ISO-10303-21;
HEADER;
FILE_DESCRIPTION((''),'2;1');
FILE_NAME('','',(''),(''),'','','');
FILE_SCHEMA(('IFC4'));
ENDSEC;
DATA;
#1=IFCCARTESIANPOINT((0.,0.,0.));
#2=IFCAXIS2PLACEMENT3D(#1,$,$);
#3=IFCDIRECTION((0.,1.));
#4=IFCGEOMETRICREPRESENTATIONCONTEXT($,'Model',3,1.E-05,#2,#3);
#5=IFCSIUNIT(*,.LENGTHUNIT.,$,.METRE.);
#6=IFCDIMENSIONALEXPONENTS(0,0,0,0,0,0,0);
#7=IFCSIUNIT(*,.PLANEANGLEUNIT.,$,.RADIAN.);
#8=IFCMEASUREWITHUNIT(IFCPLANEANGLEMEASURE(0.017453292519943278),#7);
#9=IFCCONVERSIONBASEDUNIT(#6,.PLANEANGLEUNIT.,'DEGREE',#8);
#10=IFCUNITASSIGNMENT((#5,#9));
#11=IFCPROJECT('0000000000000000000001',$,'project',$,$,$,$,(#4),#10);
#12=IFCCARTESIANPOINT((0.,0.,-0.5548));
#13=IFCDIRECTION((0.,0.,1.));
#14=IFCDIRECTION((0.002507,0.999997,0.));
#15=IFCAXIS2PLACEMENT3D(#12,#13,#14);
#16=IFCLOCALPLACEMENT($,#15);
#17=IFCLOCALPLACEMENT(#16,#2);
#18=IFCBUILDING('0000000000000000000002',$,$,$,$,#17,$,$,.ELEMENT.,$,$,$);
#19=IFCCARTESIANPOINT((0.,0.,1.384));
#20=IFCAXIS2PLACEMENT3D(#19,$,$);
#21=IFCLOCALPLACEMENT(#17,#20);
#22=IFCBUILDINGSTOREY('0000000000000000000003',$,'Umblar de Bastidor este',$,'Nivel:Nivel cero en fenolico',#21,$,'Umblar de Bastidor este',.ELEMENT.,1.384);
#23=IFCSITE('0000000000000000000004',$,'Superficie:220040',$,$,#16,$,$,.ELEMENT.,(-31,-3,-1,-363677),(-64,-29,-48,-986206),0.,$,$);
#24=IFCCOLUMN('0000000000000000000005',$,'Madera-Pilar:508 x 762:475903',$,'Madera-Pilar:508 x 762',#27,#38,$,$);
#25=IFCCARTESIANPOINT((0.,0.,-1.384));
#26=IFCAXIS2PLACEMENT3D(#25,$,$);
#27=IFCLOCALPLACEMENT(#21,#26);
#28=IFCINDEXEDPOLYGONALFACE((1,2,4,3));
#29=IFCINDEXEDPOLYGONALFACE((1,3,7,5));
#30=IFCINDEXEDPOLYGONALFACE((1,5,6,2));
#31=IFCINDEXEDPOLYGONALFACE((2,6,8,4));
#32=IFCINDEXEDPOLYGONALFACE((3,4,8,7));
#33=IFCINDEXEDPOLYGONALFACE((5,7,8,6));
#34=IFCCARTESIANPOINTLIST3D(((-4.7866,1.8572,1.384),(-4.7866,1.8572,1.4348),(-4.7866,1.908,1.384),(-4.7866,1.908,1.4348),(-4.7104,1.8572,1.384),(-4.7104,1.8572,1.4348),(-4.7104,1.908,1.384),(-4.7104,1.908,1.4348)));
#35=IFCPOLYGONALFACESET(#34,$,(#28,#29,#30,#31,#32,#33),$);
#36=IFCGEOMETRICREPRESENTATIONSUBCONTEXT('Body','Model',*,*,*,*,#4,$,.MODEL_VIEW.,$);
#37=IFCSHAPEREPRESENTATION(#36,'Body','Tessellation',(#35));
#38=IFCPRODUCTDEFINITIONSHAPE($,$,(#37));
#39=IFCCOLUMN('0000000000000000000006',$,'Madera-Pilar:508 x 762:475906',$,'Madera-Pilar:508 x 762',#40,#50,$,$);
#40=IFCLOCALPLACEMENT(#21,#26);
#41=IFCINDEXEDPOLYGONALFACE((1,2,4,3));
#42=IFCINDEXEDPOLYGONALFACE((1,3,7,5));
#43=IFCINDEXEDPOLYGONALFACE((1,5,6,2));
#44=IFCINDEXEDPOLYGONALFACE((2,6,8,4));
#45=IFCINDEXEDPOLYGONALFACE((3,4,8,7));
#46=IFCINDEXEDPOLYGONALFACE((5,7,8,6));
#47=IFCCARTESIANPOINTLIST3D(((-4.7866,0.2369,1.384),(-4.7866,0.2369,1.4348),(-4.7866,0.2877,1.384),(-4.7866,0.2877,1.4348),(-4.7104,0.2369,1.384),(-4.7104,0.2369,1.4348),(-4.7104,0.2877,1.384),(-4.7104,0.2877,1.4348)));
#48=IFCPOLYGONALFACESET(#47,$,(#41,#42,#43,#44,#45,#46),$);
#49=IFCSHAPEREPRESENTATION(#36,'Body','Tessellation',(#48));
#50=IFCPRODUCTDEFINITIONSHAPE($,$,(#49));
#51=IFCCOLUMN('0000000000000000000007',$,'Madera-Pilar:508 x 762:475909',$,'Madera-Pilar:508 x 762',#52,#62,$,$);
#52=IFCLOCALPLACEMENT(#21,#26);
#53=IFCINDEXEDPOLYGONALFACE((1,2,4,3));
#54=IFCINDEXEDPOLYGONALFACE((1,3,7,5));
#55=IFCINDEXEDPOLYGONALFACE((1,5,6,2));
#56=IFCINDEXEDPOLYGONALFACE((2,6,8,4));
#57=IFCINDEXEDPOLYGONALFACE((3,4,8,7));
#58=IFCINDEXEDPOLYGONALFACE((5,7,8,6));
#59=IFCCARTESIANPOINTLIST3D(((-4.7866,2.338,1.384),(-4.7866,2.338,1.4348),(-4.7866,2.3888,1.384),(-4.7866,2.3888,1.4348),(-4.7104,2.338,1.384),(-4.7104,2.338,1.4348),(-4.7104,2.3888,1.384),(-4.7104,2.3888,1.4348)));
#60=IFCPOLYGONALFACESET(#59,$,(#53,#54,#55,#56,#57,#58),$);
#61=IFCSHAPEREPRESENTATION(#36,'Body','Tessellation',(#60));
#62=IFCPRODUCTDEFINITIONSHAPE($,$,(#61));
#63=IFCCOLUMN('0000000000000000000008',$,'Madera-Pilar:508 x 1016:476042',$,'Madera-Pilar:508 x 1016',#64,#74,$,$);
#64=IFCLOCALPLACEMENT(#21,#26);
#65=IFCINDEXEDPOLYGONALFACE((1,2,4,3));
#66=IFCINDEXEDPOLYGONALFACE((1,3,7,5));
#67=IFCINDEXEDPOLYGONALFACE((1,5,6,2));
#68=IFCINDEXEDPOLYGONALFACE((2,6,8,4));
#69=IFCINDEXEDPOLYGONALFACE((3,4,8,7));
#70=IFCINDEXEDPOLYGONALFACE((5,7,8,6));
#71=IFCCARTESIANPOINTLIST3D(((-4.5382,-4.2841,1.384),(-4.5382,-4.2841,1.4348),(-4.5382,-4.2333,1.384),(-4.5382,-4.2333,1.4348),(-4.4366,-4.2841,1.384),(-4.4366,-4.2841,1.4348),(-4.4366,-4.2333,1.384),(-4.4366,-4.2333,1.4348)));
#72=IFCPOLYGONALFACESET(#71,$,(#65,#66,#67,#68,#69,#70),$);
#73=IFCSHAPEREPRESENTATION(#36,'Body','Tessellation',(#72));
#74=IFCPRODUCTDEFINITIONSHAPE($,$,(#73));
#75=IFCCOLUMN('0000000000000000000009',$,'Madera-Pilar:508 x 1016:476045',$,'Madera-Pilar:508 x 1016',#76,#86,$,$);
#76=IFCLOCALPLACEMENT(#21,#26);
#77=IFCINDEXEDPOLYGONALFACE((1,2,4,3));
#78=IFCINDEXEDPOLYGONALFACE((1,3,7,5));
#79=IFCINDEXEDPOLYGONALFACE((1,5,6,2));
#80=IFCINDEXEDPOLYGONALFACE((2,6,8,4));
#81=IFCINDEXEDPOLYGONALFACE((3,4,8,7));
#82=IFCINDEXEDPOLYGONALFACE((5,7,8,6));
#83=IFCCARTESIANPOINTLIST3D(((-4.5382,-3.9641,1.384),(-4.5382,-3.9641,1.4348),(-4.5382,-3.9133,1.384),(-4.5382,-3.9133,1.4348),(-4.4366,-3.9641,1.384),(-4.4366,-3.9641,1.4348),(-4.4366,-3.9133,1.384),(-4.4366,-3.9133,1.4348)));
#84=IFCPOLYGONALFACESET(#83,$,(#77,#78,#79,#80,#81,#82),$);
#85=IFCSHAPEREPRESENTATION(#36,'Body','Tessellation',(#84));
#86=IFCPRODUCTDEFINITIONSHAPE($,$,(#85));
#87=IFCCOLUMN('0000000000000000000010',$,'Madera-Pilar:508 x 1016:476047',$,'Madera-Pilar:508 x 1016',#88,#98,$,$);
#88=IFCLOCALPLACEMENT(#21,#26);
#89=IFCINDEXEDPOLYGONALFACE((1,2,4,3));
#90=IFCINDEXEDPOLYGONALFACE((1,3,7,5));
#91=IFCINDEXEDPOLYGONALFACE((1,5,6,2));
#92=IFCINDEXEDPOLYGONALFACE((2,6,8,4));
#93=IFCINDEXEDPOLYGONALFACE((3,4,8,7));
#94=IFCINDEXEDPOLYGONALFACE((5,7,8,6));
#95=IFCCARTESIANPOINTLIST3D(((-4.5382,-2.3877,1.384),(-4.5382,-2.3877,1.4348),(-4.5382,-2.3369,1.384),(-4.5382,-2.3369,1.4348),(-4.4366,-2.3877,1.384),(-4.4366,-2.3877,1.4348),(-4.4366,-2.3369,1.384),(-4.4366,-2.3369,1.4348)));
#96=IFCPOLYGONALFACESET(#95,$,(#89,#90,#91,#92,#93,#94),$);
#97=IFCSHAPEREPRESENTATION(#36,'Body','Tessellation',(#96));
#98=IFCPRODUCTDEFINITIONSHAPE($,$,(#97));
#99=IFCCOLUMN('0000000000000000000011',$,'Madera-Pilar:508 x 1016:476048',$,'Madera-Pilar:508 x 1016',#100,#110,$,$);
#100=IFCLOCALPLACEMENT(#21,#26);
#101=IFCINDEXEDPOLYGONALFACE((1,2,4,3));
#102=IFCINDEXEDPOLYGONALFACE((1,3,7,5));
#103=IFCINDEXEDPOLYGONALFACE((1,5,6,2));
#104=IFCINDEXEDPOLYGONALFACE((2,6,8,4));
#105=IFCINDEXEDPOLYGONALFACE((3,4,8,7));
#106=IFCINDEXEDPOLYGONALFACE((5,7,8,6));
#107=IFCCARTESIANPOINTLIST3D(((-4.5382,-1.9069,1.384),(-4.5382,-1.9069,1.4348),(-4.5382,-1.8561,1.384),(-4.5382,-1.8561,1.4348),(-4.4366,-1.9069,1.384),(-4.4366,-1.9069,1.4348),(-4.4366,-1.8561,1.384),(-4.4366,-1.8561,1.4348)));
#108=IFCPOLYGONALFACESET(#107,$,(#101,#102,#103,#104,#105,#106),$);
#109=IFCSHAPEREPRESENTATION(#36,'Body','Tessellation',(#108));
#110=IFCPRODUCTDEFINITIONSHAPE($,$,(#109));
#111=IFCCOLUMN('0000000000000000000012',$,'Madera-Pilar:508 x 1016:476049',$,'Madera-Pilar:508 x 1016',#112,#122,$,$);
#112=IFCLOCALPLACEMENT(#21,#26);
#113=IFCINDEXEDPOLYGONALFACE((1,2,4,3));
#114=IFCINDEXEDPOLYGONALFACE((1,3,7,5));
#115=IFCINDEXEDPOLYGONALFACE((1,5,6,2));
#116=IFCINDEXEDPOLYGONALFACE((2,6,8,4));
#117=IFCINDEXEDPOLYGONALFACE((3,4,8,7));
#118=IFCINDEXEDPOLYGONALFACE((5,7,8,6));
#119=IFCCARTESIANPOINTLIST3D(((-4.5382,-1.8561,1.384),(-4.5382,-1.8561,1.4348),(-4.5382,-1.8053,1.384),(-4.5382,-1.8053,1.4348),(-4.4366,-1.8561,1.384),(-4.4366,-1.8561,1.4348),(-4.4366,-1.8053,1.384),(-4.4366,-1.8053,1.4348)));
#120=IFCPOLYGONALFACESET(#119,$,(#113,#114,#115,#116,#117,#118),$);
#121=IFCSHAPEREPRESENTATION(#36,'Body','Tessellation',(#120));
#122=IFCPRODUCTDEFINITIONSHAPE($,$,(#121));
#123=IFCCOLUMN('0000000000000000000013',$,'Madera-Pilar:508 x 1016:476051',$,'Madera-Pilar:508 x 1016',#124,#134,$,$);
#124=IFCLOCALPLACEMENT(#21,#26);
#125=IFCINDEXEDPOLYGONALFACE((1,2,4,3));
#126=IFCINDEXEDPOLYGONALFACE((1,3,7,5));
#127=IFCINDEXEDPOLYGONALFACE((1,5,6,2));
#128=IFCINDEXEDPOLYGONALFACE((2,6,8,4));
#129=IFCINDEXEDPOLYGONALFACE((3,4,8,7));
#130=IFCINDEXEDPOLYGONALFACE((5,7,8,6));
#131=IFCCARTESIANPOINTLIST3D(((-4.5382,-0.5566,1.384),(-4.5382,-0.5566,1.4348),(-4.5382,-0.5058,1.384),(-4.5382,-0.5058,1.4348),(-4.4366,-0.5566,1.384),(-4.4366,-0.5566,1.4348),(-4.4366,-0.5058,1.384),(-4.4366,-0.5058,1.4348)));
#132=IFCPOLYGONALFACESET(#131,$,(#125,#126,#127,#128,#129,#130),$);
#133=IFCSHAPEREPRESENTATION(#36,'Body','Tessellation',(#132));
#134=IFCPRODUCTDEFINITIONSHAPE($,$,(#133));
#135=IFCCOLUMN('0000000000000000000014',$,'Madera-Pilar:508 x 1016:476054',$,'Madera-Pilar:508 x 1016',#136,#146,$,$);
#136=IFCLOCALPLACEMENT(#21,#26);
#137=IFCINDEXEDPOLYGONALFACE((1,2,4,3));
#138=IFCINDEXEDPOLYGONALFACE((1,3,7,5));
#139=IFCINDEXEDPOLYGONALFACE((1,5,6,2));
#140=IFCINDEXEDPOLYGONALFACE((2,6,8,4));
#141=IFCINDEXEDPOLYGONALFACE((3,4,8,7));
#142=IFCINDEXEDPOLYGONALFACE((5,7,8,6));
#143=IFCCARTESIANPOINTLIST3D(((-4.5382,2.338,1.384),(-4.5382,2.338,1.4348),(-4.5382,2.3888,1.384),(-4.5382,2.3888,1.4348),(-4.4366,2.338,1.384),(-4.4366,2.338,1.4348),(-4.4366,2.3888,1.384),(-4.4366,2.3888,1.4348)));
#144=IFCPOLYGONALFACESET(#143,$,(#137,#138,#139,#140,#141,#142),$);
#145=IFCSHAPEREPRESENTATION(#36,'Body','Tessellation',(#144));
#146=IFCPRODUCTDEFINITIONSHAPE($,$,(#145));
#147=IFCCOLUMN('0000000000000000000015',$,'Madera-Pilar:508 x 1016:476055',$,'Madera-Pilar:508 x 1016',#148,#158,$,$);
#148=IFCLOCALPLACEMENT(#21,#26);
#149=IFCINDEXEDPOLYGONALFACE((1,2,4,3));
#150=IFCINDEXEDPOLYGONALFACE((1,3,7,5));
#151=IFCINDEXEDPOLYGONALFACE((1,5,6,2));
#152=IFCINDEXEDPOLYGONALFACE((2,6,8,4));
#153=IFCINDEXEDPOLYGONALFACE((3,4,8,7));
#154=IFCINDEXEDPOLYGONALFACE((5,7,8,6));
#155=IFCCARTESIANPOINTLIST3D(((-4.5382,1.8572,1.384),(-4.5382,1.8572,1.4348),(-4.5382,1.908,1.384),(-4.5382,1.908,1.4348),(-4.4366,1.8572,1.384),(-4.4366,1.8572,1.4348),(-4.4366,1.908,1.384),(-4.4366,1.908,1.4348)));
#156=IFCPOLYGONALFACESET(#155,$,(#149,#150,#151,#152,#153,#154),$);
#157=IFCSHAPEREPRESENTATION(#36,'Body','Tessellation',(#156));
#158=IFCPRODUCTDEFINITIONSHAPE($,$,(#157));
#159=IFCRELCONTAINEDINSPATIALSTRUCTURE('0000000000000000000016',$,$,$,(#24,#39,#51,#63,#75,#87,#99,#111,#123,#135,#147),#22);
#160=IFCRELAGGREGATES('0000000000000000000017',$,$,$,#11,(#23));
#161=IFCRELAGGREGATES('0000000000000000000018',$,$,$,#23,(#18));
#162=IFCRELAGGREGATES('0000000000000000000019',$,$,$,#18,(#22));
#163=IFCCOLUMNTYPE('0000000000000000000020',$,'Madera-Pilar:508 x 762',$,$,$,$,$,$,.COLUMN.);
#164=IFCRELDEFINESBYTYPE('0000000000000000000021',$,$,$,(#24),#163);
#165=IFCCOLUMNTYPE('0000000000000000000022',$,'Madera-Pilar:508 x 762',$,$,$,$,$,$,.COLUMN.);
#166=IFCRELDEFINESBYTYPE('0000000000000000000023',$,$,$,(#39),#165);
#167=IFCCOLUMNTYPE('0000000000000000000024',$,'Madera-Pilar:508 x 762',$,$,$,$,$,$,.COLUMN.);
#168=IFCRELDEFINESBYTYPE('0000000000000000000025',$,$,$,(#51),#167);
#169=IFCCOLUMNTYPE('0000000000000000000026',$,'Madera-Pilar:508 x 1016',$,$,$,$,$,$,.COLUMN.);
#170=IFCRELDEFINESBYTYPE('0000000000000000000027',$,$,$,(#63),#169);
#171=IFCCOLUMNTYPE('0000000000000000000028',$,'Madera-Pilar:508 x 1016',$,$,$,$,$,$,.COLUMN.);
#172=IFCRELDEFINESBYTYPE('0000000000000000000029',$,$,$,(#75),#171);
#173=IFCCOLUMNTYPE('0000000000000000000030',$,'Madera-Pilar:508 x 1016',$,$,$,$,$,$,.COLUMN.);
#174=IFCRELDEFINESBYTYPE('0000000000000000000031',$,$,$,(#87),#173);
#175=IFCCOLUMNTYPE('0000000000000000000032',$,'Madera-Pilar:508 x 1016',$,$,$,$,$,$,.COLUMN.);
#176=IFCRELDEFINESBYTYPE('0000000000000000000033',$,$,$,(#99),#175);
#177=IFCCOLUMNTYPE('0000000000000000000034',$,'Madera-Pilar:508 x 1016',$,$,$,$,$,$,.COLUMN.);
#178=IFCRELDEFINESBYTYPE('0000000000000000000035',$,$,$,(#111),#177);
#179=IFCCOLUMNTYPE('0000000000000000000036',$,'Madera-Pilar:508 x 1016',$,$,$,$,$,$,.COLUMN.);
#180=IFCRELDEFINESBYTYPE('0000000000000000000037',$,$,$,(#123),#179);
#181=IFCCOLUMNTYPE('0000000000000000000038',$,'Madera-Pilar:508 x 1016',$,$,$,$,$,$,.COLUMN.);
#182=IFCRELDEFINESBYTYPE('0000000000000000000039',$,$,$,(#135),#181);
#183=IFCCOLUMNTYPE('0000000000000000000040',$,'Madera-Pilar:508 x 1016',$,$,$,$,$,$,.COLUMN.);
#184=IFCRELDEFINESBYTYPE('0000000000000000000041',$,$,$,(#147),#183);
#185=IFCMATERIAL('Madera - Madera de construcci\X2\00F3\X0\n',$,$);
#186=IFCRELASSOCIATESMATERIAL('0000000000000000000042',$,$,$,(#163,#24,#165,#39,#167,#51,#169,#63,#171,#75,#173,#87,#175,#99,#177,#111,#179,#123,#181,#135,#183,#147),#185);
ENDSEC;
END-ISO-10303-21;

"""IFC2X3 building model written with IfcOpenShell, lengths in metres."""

from ifc_helpers import new_model, entity, si_unit, converted_unit, direction, frame, frame_2d, origin, origin_2d_with_axis, place, context, subcontext, project, spatial, rectangle, extrude, source, transform, mapped, material, type_object, type_shapes, element, save


model = new_model("IFC2X3")

# Units and contexts
model_context = context("Model", 3, precision=1e-05, world=origin(), true_north=direction((0.0, 1.0)))
body_context = subcontext(model_context, "Body", "Model", "MODEL_VIEW")
ifc_project = project(units=[si_unit("LENGTHUNIT", "METRE"), converted_unit("PLANEANGLEUNIT", "DEGREE", entity("IfcPlaneAngleMeasure", 0.017453292519943278), si_unit("PLANEANGLEUNIT", "RADIAN"), dimensions=[0, 0, 0, 0, 0, 0, 0])], contexts=[model_context])

# Site, building, storey
site_placement = place(None, frame((0.0, 0.0, -0.5548), z_axis=(0.0, 0.0, 1.0), x_axis=(0.002507, 0.999997, 0.0)))
site = spatial("IfcSite", under=ifc_project, at=site_placement, Name="Superficie:220040", CompositionType="ELEMENT", RefLatitude=(-31, -3, -1, -363677), RefLongitude=(-64, -29, -48, -986206), RefElevation=0.0)
building_placement = place(site_placement, origin())
building = spatial("IfcBuilding", under=site, at=building_placement, CompositionType="ELEMENT")
storey_placement = place(building_placement, frame((0.0, 0.0, 1.384)))
storey = spatial("IfcBuildingStorey", under=building, at=storey_placement, Name="Umblar de Bastidor este", ObjectType="Nivel:Nivel cero en fenolico", LongName="Umblar de Bastidor este", CompositionType="ELEMENT", Elevation=1.384)

# Columns
ifc_material = material(Name="Madera - Madera de construcción")
column_type_1 = type_object("IfcColumnType", Name="Madera-Pilar:508 x 762", PredefinedType="COLUMN", material=ifc_material)
shared_shape_1 = source(origin(), body_context, "Body", "SweptSolid", [
    extrude(rectangle(XDim=0.0762, YDim=0.0508, at=origin_2d_with_axis()), frame((-4.7485, 1.8826, 1.384), z_axis=(0.0, 0.0, 1.0), x_axis=(-1.0, 0.0, 0.0)), (0.0, 0.0, 1.0), 0.0508),
])
type_shapes(column_type_1, [shared_shape_1])
column_1_placement = place(storey_placement, frame((0.0, 0.0, -1.384)))
element("IfcColumn", 1, at=column_1_placement, inside=storey, type_object=column_type_1, material=ifc_material, Name="Madera-Pilar:508 x 762:475903", ObjectType="Madera-Pilar:508 x 762", context=body_context, shape_type="MappedRepresentation", body=[
    mapped(shared_shape_1, transform((0.0, 0.0, 0.0), scale=1.0)),
])
column_type_2 = type_object("IfcColumnType", Name="Madera-Pilar:508 x 762", PredefinedType="COLUMN", material=ifc_material)
shared_shape_2 = source(origin(), body_context, "Body", "SweptSolid", [
    extrude(rectangle(XDim=0.0762, YDim=0.0508, at=frame_2d((0.0, 0.0), x_axis=(1.0, 0.0))), frame((-4.7485, 0.2623, 1.384), z_axis=(0.0, 0.0, 1.0), x_axis=(-1.0, 0.0, 0.0)), (0.0, 0.0, 1.0), 0.0508),
])
type_shapes(column_type_2, [shared_shape_2])
column_2_placement = place(storey_placement, frame((0.0, 0.0, -1.384)))
element("IfcColumn", 2, at=column_2_placement, inside=storey, type_object=column_type_2, material=ifc_material, Name="Madera-Pilar:508 x 762:475906", ObjectType="Madera-Pilar:508 x 762", context=body_context, shape_type="MappedRepresentation", body=[
    mapped(shared_shape_2, transform((0.0, 0.0, 0.0), scale=1.0)),
])
column_type_3 = type_object("IfcColumnType", Name="Madera-Pilar:508 x 762", PredefinedType="COLUMN", material=ifc_material)
shared_shape_3 = source(origin(), body_context, "Body", "SweptSolid", [
    extrude(rectangle(XDim=0.0762, YDim=0.0508, at=origin_2d_with_axis()), frame((-4.7485, 2.3634, 1.384), z_axis=(0.0, 0.0, 1.0), x_axis=(-1.0, 0.0, 0.0)), (0.0, 0.0, 1.0), 0.0508),
])
type_shapes(column_type_3, [shared_shape_3])
column_3_placement = place(storey_placement, frame((0.0, 0.0, -1.384)))
element("IfcColumn", 3, at=column_3_placement, inside=storey, type_object=column_type_3, material=ifc_material, Name="Madera-Pilar:508 x 762:475909", ObjectType="Madera-Pilar:508 x 762", context=body_context, shape_type="MappedRepresentation", body=[
    mapped(shared_shape_3, transform((0.0, 0.0, 0.0), scale=1.0)),
])
column_type_4 = type_object("IfcColumnType", Name="Madera-Pilar:508 x 1016", PredefinedType="COLUMN", material=ifc_material)
shared_shape_4 = source(origin(), body_context, "Body", "SweptSolid", [
    extrude(rectangle(XDim=0.1016, YDim=0.0508, at=frame_2d((0.0, 0.0), x_axis=(1.0, 0.0))), frame((-4.4874, -4.2587, 1.384), z_axis=(0.0, 0.0, 1.0), x_axis=(-1.0, 0.0, 0.0)), (0.0, 0.0, 1.0), 0.0508),
])
type_shapes(column_type_4, [shared_shape_4])
column_4_placement = place(storey_placement, frame((0.0, 0.0, -1.384)))
element("IfcColumn", 4, at=column_4_placement, inside=storey, type_object=column_type_4, material=ifc_material, Name="Madera-Pilar:508 x 1016:476042", ObjectType="Madera-Pilar:508 x 1016", context=body_context, shape_type="MappedRepresentation", body=[
    mapped(shared_shape_4, transform((0.0, 0.0, 0.0), scale=1.0)),
])
column_type_5 = type_object("IfcColumnType", Name="Madera-Pilar:508 x 1016", PredefinedType="COLUMN", material=ifc_material)
shared_shape_5 = source(origin(), body_context, "Body", "SweptSolid", [
    extrude(rectangle(XDim=0.1016, YDim=0.0508, at=frame_2d((0.0, 0.0), x_axis=(1.0, 0.0))), frame((-4.4874, -3.9387, 1.384), z_axis=(0.0, 0.0, 1.0), x_axis=(-1.0, 0.0, 0.0)), (0.0, 0.0, 1.0), 0.0508),
])
type_shapes(column_type_5, [shared_shape_5])
column_5_placement = place(storey_placement, frame((0.0, 0.0, -1.384)))
element("IfcColumn", 5, at=column_5_placement, inside=storey, type_object=column_type_5, material=ifc_material, Name="Madera-Pilar:508 x 1016:476045", ObjectType="Madera-Pilar:508 x 1016", context=body_context, shape_type="MappedRepresentation", body=[
    mapped(shared_shape_5, transform((0.0, 0.0, 0.0), scale=1.0)),
])
column_type_6 = type_object("IfcColumnType", Name="Madera-Pilar:508 x 1016", PredefinedType="COLUMN", material=ifc_material)
shared_shape_6 = source(origin(), body_context, "Body", "SweptSolid", [
    extrude(rectangle(XDim=0.1016, YDim=0.0508, at=frame_2d((0.0, 0.0), x_axis=(1.0, 0.0))), frame((-4.4874, -2.3623, 1.384), z_axis=(0.0, 0.0, 1.0), x_axis=(-1.0, 0.0, 0.0)), (0.0, 0.0, 1.0), 0.0508),
])
type_shapes(column_type_6, [shared_shape_6])
column_6_placement = place(storey_placement, frame((0.0, 0.0, -1.384)))
element("IfcColumn", 6, at=column_6_placement, inside=storey, type_object=column_type_6, material=ifc_material, Name="Madera-Pilar:508 x 1016:476047", ObjectType="Madera-Pilar:508 x 1016", context=body_context, shape_type="MappedRepresentation", body=[
    mapped(shared_shape_6, transform((0.0, 0.0, 0.0), scale=1.0)),
])
column_type_7 = type_object("IfcColumnType", Name="Madera-Pilar:508 x 1016", PredefinedType="COLUMN", material=ifc_material)
shared_shape_7 = source(origin(), body_context, "Body", "SweptSolid", [
    extrude(rectangle(XDim=0.1016, YDim=0.0508, at=frame_2d((0.0, 0.0), x_axis=(1.0, 0.0))), frame((-4.4874, -1.8815, 1.384), z_axis=(0.0, 0.0, 1.0), x_axis=(-1.0, 0.0, 0.0)), (0.0, 0.0, 1.0), 0.0508),
])
type_shapes(column_type_7, [shared_shape_7])
column_7_placement = place(storey_placement, frame((0.0, 0.0, -1.384)))
element("IfcColumn", 7, at=column_7_placement, inside=storey, type_object=column_type_7, material=ifc_material, Name="Madera-Pilar:508 x 1016:476048", ObjectType="Madera-Pilar:508 x 1016", context=body_context, shape_type="MappedRepresentation", body=[
    mapped(shared_shape_7, transform((0.0, 0.0, 0.0), scale=1.0)),
])
column_type_8 = type_object("IfcColumnType", Name="Madera-Pilar:508 x 1016", PredefinedType="COLUMN", material=ifc_material)
shared_shape_8 = source(origin(), body_context, "Body", "SweptSolid", [
    extrude(rectangle(XDim=0.1016, YDim=0.0508, at=frame_2d((0.0, 0.0), x_axis=(1.0, 0.0))), frame((-4.4874, -1.8307, 1.384), z_axis=(0.0, 0.0, 1.0), x_axis=(-1.0, 0.0, 0.0)), (0.0, 0.0, 1.0), 0.0508),
])
type_shapes(column_type_8, [shared_shape_8])
column_8_placement = place(storey_placement, frame((0.0, 0.0, -1.384)))
element("IfcColumn", 8, at=column_8_placement, inside=storey, type_object=column_type_8, material=ifc_material, Name="Madera-Pilar:508 x 1016:476049", ObjectType="Madera-Pilar:508 x 1016", context=body_context, shape_type="MappedRepresentation", body=[
    mapped(shared_shape_8, transform((0.0, 0.0, 0.0), scale=1.0)),
])
column_type_9 = type_object("IfcColumnType", Name="Madera-Pilar:508 x 1016", PredefinedType="COLUMN", material=ifc_material)
shared_shape_9 = source(origin(), body_context, "Body", "SweptSolid", [
    extrude(rectangle(XDim=0.1016, YDim=0.0508, at=frame_2d((0.0, 0.0), x_axis=(1.0, 0.0))), frame((-4.4874, -0.5312, 1.384), z_axis=(0.0, 0.0, 1.0), x_axis=(-1.0, 0.0, 0.0)), (0.0, 0.0, 1.0), 0.0508),
])
type_shapes(column_type_9, [shared_shape_9])
column_9_placement = place(storey_placement, frame((0.0, 0.0, -1.384)))
element("IfcColumn", 9, at=column_9_placement, inside=storey, type_object=column_type_9, material=ifc_material, Name="Madera-Pilar:508 x 1016:476051", ObjectType="Madera-Pilar:508 x 1016", context=body_context, shape_type="MappedRepresentation", body=[
    mapped(shared_shape_9, transform((0.0, 0.0, 0.0), scale=1.0)),
])
column_type_10 = type_object("IfcColumnType", Name="Madera-Pilar:508 x 1016", PredefinedType="COLUMN", material=ifc_material)
shared_shape_10 = source(origin(), body_context, "Body", "SweptSolid", [
    extrude(rectangle(XDim=0.1016, YDim=0.0508, at=frame_2d((0.0, 0.0), x_axis=(1.0, 0.0))), frame((-4.4874, 2.3634, 1.384), z_axis=(0.0, 0.0, 1.0), x_axis=(-1.0, 0.0, 0.0)), (0.0, 0.0, 1.0), 0.0508),
])
type_shapes(column_type_10, [shared_shape_10])
column_10_placement = place(storey_placement, frame((0.0, 0.0, -1.384)))
element("IfcColumn", 10, at=column_10_placement, inside=storey, type_object=column_type_10, material=ifc_material, Name="Madera-Pilar:508 x 1016:476054", ObjectType="Madera-Pilar:508 x 1016", context=body_context, shape_type="MappedRepresentation", body=[
    mapped(shared_shape_10, transform((0.0, 0.0, 0.0), scale=1.0)),
])
column_type_11 = type_object("IfcColumnType", Name="Madera-Pilar:508 x 1016", PredefinedType="COLUMN", material=ifc_material)
shared_shape_11 = source(origin(), body_context, "Body", "SweptSolid", [
    extrude(rectangle(XDim=0.1016, YDim=0.0508, at=frame_2d((0.0, 0.0), x_axis=(1.0, 0.0))), frame((-4.4874, 1.8826, 1.384), z_axis=(0.0, 0.0, 1.0), x_axis=(-1.0, 0.0, 0.0)), (0.0, 0.0, 1.0), 0.0508),
])
type_shapes(column_type_11, [shared_shape_11])
column_11_placement = place(storey_placement, frame((0.0, 0.0, -1.384)))
element("IfcColumn", 11, at=column_11_placement, inside=storey, type_object=column_type_11, material=ifc_material, Name="Madera-Pilar:508 x 1016:476055", ObjectType="Madera-Pilar:508 x 1016", context=body_context, shape_type="MappedRepresentation", body=[
    mapped(shared_shape_11, transform((0.0, 0.0, 0.0), scale=1.0)),
])

save(model, "model.ifc")
